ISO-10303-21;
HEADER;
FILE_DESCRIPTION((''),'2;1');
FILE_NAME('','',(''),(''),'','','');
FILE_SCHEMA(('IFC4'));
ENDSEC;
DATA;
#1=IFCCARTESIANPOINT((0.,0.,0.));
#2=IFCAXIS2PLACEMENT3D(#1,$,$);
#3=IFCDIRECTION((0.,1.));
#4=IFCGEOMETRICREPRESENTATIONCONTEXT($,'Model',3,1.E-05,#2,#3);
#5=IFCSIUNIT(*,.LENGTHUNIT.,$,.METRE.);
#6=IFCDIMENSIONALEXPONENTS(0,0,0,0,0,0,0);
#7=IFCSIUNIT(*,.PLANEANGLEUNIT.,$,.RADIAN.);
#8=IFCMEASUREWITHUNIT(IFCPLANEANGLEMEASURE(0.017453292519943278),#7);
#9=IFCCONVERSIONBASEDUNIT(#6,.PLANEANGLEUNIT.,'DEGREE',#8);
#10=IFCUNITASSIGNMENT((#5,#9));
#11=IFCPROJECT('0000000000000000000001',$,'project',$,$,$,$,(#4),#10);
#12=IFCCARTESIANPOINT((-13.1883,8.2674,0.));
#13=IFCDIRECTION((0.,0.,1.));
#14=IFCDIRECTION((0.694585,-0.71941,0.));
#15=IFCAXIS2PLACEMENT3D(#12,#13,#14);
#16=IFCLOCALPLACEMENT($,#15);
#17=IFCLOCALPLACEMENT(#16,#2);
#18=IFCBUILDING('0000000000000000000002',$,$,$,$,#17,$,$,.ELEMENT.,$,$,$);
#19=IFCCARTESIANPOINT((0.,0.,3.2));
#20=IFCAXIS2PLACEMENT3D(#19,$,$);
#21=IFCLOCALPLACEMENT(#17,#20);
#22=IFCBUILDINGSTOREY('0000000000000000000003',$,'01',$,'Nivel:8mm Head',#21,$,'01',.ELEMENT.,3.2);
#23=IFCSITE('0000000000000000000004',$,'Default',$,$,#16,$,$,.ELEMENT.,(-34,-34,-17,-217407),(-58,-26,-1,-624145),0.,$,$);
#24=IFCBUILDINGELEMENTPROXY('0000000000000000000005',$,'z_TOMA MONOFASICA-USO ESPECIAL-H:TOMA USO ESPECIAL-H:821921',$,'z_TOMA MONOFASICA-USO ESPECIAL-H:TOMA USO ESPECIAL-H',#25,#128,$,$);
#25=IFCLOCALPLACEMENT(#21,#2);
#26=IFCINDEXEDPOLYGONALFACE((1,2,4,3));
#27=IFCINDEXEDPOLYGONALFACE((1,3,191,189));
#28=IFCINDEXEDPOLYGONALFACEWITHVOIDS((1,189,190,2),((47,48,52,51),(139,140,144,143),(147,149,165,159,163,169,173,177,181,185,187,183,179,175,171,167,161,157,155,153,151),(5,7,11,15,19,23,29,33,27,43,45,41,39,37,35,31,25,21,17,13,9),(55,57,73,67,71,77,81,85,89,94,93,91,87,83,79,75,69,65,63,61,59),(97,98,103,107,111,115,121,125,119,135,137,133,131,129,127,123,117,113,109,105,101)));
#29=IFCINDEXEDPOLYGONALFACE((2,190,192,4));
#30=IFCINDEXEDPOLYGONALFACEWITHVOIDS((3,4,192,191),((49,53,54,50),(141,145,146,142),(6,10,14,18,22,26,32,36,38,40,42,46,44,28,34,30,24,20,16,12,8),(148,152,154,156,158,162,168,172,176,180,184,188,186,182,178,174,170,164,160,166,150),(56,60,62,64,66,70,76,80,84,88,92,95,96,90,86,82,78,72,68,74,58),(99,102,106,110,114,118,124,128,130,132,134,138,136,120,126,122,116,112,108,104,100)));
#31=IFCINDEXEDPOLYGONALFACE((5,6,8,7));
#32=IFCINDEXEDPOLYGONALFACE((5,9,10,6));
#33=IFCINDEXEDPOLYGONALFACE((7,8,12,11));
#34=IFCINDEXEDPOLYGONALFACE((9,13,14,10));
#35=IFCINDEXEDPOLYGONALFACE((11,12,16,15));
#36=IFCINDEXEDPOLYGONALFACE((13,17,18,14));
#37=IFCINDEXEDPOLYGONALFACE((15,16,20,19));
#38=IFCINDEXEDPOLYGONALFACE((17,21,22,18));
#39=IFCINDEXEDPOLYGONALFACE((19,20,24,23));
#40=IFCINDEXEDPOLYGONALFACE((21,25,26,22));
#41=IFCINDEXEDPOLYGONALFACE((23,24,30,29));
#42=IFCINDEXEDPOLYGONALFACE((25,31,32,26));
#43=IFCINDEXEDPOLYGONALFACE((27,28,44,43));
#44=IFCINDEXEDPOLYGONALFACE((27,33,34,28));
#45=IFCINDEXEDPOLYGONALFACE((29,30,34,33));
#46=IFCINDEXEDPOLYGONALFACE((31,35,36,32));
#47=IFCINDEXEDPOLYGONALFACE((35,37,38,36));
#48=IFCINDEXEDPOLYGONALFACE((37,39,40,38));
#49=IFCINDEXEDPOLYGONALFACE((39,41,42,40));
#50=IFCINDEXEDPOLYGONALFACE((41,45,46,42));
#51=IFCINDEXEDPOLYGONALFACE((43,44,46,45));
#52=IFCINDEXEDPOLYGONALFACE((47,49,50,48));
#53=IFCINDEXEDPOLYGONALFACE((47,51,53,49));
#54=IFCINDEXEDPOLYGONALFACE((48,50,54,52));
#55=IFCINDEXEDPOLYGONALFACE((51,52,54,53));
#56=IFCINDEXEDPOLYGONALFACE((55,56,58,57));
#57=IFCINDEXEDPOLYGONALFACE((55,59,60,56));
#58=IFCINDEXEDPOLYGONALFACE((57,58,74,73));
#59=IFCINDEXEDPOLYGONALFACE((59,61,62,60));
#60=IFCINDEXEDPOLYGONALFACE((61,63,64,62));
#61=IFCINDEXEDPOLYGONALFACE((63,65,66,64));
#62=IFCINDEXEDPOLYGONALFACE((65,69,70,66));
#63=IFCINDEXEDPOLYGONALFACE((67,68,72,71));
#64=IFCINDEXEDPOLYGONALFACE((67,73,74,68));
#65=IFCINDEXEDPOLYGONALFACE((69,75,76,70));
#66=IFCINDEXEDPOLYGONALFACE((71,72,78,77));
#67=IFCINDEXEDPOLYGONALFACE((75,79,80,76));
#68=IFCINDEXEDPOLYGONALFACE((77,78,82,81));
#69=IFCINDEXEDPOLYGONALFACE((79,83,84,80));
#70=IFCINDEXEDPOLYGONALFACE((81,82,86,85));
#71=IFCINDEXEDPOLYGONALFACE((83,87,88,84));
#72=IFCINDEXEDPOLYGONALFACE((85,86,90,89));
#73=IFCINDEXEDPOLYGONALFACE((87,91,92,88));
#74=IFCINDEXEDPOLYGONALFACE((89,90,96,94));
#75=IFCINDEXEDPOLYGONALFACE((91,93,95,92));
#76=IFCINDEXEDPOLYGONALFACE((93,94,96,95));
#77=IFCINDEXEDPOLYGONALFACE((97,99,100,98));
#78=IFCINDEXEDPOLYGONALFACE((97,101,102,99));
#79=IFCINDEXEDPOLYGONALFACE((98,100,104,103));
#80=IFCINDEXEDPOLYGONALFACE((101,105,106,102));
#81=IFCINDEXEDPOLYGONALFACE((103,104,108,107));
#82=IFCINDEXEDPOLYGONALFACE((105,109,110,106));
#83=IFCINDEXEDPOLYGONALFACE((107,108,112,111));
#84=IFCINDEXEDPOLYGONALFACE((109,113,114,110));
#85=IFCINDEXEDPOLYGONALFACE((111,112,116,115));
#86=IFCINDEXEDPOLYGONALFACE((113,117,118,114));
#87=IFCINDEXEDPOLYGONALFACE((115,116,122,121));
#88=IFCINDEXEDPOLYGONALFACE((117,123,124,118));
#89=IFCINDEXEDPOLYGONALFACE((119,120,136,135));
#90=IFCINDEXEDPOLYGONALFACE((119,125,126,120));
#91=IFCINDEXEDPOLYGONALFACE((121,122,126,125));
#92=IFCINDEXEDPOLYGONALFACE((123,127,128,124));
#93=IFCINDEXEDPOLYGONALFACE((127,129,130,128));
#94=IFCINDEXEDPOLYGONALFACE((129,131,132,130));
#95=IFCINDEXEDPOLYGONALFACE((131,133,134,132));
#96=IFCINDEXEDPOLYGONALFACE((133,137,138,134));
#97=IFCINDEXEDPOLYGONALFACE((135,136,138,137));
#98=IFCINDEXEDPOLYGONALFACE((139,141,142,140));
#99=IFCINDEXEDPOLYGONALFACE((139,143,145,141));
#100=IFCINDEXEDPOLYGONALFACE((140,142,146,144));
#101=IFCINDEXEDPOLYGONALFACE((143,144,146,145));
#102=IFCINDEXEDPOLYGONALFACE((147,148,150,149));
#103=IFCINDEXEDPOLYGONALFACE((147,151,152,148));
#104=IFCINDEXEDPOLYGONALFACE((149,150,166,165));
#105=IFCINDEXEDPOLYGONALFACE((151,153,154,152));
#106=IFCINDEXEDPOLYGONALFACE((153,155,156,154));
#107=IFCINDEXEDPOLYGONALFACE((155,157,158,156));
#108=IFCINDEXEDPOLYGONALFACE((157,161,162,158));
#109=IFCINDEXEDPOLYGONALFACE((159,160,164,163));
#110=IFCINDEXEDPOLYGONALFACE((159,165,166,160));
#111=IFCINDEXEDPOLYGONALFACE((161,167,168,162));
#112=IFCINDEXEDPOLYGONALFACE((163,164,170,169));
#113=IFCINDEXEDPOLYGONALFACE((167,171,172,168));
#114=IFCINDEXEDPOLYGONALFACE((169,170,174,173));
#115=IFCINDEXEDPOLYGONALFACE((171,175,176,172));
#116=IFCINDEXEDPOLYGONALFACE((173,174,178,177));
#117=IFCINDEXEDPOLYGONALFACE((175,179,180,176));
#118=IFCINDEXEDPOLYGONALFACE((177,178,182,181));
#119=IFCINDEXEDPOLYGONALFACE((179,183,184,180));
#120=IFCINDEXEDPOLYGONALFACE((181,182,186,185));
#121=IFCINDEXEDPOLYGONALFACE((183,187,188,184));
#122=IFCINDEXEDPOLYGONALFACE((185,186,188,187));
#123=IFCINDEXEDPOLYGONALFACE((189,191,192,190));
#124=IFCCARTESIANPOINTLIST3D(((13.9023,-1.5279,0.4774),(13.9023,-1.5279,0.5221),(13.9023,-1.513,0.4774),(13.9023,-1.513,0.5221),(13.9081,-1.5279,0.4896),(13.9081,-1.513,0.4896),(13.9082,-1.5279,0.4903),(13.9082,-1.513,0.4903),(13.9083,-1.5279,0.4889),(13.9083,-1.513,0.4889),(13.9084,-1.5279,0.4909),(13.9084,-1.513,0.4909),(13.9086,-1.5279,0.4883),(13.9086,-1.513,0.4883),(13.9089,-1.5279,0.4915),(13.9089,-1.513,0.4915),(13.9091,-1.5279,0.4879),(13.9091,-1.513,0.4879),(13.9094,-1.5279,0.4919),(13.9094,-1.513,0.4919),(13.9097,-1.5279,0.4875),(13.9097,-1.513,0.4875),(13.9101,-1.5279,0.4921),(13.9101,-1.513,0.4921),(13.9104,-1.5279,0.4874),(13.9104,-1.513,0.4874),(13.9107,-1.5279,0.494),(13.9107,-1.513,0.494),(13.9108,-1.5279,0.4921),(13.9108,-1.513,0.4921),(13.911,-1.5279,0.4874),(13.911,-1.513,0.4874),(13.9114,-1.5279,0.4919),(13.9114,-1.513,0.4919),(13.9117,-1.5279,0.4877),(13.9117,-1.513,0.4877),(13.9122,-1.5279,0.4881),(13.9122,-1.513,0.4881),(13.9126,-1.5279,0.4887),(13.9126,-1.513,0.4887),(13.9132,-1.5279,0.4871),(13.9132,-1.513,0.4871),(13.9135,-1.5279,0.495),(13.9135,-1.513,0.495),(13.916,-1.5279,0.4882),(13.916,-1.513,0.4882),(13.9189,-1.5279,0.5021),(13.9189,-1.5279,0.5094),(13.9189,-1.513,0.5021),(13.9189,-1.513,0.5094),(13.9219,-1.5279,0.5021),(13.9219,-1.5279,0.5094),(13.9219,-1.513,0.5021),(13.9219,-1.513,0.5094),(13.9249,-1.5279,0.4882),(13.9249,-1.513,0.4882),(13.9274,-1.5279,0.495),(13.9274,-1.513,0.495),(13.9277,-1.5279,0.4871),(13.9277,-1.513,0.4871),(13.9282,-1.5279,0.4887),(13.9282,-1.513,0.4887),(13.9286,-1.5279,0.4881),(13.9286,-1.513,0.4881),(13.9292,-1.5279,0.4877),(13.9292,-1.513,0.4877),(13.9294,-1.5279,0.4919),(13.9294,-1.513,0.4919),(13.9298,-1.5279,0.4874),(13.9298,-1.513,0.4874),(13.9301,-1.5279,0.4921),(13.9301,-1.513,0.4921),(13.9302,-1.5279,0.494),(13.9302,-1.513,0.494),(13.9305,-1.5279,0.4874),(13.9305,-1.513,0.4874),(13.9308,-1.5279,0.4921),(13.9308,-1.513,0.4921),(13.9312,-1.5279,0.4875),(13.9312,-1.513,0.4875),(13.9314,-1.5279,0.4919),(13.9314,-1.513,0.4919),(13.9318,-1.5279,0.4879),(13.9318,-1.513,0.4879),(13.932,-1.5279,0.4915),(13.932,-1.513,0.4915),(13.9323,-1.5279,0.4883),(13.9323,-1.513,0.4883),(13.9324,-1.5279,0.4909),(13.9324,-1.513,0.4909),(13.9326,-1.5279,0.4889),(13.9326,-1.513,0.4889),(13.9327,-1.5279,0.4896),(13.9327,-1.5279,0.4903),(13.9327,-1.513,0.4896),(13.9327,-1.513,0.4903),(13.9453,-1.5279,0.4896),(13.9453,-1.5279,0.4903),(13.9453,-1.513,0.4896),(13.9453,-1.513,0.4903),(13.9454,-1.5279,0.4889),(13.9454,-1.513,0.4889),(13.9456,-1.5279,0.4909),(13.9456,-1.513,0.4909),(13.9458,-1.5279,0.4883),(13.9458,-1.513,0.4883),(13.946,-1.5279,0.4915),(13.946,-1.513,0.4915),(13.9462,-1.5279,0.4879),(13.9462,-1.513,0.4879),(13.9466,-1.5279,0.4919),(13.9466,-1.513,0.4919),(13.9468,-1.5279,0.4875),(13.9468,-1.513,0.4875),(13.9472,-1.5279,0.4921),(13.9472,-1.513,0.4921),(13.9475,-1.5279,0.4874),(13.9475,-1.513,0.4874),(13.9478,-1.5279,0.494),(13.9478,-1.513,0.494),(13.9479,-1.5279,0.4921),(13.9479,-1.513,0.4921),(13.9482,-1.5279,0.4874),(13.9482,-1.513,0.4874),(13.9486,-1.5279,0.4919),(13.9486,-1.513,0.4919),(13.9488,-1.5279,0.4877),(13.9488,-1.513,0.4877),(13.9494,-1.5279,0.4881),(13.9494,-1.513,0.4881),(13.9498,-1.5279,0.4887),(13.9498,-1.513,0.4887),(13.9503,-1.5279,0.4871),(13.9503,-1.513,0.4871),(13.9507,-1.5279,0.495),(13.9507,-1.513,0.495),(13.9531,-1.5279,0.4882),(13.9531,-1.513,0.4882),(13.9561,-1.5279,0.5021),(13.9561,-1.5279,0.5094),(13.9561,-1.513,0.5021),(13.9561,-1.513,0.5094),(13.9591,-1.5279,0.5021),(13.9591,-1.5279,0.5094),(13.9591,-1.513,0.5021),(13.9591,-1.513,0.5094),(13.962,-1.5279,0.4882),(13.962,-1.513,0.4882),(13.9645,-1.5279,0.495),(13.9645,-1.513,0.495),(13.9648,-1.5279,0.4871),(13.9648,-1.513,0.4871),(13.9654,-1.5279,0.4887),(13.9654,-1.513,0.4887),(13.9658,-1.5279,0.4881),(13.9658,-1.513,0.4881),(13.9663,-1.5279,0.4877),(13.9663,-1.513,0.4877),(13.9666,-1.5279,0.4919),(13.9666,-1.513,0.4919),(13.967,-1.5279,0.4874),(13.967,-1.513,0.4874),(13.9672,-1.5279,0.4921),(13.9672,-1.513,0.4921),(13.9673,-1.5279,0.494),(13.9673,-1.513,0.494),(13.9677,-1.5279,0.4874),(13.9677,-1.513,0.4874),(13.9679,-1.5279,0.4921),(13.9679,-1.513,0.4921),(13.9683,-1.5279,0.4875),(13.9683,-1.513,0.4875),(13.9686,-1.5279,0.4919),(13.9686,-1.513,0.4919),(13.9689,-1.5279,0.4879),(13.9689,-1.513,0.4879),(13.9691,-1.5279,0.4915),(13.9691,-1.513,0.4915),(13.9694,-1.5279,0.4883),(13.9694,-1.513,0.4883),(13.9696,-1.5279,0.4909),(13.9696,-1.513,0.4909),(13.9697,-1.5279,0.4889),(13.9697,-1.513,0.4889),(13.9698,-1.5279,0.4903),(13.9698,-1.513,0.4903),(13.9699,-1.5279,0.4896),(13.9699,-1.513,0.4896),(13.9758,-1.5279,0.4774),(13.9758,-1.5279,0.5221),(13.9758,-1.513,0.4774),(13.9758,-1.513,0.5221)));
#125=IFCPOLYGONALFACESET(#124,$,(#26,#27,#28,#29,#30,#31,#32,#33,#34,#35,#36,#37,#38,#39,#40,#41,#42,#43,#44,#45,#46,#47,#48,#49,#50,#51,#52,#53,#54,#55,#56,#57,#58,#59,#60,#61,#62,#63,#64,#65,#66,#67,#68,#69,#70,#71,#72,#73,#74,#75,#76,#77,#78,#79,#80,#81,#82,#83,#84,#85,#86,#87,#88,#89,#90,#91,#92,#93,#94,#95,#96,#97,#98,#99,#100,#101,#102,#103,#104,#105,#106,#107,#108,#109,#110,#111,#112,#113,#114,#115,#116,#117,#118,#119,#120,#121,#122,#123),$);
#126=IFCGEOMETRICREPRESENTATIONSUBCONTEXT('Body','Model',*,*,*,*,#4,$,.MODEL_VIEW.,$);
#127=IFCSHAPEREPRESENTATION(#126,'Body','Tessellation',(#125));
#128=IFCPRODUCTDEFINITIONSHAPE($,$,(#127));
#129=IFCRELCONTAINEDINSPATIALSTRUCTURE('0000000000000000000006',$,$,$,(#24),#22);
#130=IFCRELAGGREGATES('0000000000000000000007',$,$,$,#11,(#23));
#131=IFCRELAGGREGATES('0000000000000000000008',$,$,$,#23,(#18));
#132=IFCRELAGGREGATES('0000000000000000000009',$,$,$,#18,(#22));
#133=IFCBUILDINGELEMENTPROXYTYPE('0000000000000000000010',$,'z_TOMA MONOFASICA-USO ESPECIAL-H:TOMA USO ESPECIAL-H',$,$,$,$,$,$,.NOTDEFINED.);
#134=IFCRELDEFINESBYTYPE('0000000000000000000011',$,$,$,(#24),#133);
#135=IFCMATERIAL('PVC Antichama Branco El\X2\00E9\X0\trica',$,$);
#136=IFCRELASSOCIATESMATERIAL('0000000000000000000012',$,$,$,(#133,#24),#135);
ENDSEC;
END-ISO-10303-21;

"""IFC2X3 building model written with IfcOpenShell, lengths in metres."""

from ifc_helpers import new_model, entity, si_unit, converted_unit, direction, frame, frame_2d, origin, place, context, subcontext, project, spatial, polyline, circle_curve, parameter, trimmed, segment, composite_curve, outline, extrude, source, transform, mapped, material, type_object, type_shapes, element, save


model = new_model("IFC2X3")

# Units and contexts
model_context = context("Model", 3, precision=1e-05, world=origin(), true_north=direction((0.0, 1.0)))
body_context = subcontext(model_context, "Body", "Model", "MODEL_VIEW")
ifc_project = project(units=[si_unit("LENGTHUNIT", "METRE"), converted_unit("PLANEANGLEUNIT", "DEGREE", entity("IfcPlaneAngleMeasure", 0.017453292519943278), si_unit("PLANEANGLEUNIT", "RADIAN"), dimensions=[0, 0, 0, 0, 0, 0, 0])], contexts=[model_context])

# Site, building, storey
site_placement = place(None, frame((-13.1883, 8.2674, 0.0), z_axis=(0.0, 0.0, 1.0), x_axis=(0.694585, -0.71941, 0.0)))
site = spatial("IfcSite", under=ifc_project, at=site_placement, Name="Default", CompositionType="ELEMENT", RefLatitude=(-34, -34, -17, -217407), RefLongitude=(-58, -26, -1, -624145), RefElevation=0.0)
building_placement = place(site_placement, origin())
building = spatial("IfcBuilding", under=site, at=building_placement, CompositionType="ELEMENT")
storey_placement = place(building_placement, frame((0.0, 0.0, 3.2)))
storey = spatial("IfcBuildingStorey", under=building, at=storey_placement, Name="01", ObjectType="Nivel:8mm Head", LongName="01", CompositionType="ELEMENT", Elevation=3.2)

# Building element proxy
ifc_material_1 = material(Name="PVC Antichama Branco Elétrica")
building_element_proxy_type_1 = type_object("IfcBuildingElementProxyType", Name="z_TOMA MONOFASICA-USO ESPECIAL-H:TOMA USO ESPECIAL-H", PredefinedType="NOTDEFINED", material=ifc_material_1)
shared_shape_1 = source(origin(), body_context, "Body", "SweptSolid", [
    extrude(outline(polyline([(-0.0368, -0.0223), (0.0368, -0.0223), (0.0368, 0.0223), (-0.0368, 0.0223), (-0.0368, -0.0223)]), holes=[composite_curve([segment(polyline([(0.0141, 0.0115), (0.0116, 0.0047)]), True, "CONTINUOUS"), segment(polyline([(0.0116, 0.0047), (0.0088, 0.0057)]), True, "CONTINUOUS"), segment(polyline([(0.0088, 0.0057), (0.0096, 0.0078)]), True, "CONTINUOUS"), segment(trimmed(circle_curve(frame_2d((0.0087, 0.0099), x_axis=(1.0, 0.0)), 0.0024), [parameter(27.118901)], [parameter(292.881099)], True, "PARAMETER"), False, "CONTINUOUS"), segment(polyline([(0.0108, 0.011), (0.0113, 0.0126)]), True, "CONTINUOUS"), segment(polyline([(0.0113, 0.0126), (0.0141, 0.0115)]), True, "CONTINUOUS")], self_intersect=False), composite_curve([segment(polyline([(0.0255, 0.0047), (0.023, 0.0115)]), True, "CONTINUOUS"), segment(polyline([(0.023, 0.0115), (0.0258, 0.0126)]), True, "CONTINUOUS"), segment(polyline([(0.0258, 0.0126), (0.0264, 0.011)]), True, "CONTINUOUS"), segment(trimmed(circle_curve(frame_2d((0.0285, 0.0099), x_axis=(1.0, 0.0)), 0.0024), [parameter(247.118901)], [parameter(152.881099)], True, "PARAMETER"), False, "CONTINUOUS"), segment(polyline([(0.0276, 0.0078), (0.0283, 0.0057)]), True, "CONTINUOUS"), segment(polyline([(0.0283, 0.0057), (0.0255, 0.0047)]), True, "CONTINUOUS")], self_intersect=False), polyline([(0.0201, -0.0024), (0.0201, -0.0097), (0.0171, -0.0097), (0.0171, -0.0024), (0.0201, -0.0024)]), composite_curve([segment(polyline([(-0.0141, 0.0115), (-0.0113, 0.0126)]), True, "CONTINUOUS"), segment(polyline([(-0.0113, 0.0126), (-0.0108, 0.011)]), True, "CONTINUOUS"), segment(trimmed(circle_curve(frame_2d((-0.0087, 0.0099), x_axis=(1.0, 0.0)), 0.0024), [parameter(247.118901)], [parameter(152.881099)], True, "PARAMETER"), False, "CONTINUOUS"), segment(polyline([(-0.0096, 0.0078), (-0.0088, 0.0057)]), True, "CONTINUOUS"), segment(polyline([(-0.0088, 0.0057), (-0.0116, 0.0047)]), True, "CONTINUOUS"), segment(polyline([(-0.0116, 0.0047), (-0.0141, 0.0115)]), True, "CONTINUOUS")], self_intersect=False), composite_curve([segment(polyline([(-0.0255, 0.0047), (-0.0283, 0.0057)]), True, "CONTINUOUS"), segment(polyline([(-0.0283, 0.0057), (-0.0276, 0.0078)]), True, "CONTINUOUS"), segment(trimmed(circle_curve(frame_2d((-0.0285, 0.0099), x_axis=(1.0, 0.0)), 0.0024), [parameter(27.118901)], [parameter(292.881099)], True, "PARAMETER"), False, "CONTINUOUS"), segment(polyline([(-0.0264, 0.011), (-0.0258, 0.0126)]), True, "CONTINUOUS"), segment(polyline([(-0.0258, 0.0126), (-0.023, 0.0115)]), True, "CONTINUOUS"), segment(polyline([(-0.023, 0.0115), (-0.0255, 0.0047)]), True, "CONTINUOUS")], self_intersect=False), polyline([(-0.0201, -0.0024), (-0.0171, -0.0024), (-0.0171, -0.0097), (-0.0201, -0.0097), (-0.0201, -0.0024)])]), frame((0.0, -0.005, 0.0223), z_axis=(0.0, 1.0, 0.0), x_axis=(1.0, 0.0, 0.0)), (0.0, 0.0, 1.0), 0.0148),
])
type_shapes(building_element_proxy_type_1, [shared_shape_1])
for number, where, name in (
    (1, (13.939, -1.5229, 0.4774), "z_TOMA MONOFASICA-USO ESPECIAL-H:TOMA USO ESPECIAL-H:821921"),
):
    element("IfcBuildingElementProxy", number, at=place(storey_placement, frame(where)), inside=storey, type_object=building_element_proxy_type_1, material=ifc_material_1, Name=name, ObjectType="z_TOMA MONOFASICA-USO ESPECIAL-H:TOMA USO ESPECIAL-H", context=body_context, shape_type="MappedRepresentation", body=[
        mapped(shared_shape_1, transform((0.0, 0.0, 0.0), scale=1.0)),
    ])

save(model, "model.ifc")
